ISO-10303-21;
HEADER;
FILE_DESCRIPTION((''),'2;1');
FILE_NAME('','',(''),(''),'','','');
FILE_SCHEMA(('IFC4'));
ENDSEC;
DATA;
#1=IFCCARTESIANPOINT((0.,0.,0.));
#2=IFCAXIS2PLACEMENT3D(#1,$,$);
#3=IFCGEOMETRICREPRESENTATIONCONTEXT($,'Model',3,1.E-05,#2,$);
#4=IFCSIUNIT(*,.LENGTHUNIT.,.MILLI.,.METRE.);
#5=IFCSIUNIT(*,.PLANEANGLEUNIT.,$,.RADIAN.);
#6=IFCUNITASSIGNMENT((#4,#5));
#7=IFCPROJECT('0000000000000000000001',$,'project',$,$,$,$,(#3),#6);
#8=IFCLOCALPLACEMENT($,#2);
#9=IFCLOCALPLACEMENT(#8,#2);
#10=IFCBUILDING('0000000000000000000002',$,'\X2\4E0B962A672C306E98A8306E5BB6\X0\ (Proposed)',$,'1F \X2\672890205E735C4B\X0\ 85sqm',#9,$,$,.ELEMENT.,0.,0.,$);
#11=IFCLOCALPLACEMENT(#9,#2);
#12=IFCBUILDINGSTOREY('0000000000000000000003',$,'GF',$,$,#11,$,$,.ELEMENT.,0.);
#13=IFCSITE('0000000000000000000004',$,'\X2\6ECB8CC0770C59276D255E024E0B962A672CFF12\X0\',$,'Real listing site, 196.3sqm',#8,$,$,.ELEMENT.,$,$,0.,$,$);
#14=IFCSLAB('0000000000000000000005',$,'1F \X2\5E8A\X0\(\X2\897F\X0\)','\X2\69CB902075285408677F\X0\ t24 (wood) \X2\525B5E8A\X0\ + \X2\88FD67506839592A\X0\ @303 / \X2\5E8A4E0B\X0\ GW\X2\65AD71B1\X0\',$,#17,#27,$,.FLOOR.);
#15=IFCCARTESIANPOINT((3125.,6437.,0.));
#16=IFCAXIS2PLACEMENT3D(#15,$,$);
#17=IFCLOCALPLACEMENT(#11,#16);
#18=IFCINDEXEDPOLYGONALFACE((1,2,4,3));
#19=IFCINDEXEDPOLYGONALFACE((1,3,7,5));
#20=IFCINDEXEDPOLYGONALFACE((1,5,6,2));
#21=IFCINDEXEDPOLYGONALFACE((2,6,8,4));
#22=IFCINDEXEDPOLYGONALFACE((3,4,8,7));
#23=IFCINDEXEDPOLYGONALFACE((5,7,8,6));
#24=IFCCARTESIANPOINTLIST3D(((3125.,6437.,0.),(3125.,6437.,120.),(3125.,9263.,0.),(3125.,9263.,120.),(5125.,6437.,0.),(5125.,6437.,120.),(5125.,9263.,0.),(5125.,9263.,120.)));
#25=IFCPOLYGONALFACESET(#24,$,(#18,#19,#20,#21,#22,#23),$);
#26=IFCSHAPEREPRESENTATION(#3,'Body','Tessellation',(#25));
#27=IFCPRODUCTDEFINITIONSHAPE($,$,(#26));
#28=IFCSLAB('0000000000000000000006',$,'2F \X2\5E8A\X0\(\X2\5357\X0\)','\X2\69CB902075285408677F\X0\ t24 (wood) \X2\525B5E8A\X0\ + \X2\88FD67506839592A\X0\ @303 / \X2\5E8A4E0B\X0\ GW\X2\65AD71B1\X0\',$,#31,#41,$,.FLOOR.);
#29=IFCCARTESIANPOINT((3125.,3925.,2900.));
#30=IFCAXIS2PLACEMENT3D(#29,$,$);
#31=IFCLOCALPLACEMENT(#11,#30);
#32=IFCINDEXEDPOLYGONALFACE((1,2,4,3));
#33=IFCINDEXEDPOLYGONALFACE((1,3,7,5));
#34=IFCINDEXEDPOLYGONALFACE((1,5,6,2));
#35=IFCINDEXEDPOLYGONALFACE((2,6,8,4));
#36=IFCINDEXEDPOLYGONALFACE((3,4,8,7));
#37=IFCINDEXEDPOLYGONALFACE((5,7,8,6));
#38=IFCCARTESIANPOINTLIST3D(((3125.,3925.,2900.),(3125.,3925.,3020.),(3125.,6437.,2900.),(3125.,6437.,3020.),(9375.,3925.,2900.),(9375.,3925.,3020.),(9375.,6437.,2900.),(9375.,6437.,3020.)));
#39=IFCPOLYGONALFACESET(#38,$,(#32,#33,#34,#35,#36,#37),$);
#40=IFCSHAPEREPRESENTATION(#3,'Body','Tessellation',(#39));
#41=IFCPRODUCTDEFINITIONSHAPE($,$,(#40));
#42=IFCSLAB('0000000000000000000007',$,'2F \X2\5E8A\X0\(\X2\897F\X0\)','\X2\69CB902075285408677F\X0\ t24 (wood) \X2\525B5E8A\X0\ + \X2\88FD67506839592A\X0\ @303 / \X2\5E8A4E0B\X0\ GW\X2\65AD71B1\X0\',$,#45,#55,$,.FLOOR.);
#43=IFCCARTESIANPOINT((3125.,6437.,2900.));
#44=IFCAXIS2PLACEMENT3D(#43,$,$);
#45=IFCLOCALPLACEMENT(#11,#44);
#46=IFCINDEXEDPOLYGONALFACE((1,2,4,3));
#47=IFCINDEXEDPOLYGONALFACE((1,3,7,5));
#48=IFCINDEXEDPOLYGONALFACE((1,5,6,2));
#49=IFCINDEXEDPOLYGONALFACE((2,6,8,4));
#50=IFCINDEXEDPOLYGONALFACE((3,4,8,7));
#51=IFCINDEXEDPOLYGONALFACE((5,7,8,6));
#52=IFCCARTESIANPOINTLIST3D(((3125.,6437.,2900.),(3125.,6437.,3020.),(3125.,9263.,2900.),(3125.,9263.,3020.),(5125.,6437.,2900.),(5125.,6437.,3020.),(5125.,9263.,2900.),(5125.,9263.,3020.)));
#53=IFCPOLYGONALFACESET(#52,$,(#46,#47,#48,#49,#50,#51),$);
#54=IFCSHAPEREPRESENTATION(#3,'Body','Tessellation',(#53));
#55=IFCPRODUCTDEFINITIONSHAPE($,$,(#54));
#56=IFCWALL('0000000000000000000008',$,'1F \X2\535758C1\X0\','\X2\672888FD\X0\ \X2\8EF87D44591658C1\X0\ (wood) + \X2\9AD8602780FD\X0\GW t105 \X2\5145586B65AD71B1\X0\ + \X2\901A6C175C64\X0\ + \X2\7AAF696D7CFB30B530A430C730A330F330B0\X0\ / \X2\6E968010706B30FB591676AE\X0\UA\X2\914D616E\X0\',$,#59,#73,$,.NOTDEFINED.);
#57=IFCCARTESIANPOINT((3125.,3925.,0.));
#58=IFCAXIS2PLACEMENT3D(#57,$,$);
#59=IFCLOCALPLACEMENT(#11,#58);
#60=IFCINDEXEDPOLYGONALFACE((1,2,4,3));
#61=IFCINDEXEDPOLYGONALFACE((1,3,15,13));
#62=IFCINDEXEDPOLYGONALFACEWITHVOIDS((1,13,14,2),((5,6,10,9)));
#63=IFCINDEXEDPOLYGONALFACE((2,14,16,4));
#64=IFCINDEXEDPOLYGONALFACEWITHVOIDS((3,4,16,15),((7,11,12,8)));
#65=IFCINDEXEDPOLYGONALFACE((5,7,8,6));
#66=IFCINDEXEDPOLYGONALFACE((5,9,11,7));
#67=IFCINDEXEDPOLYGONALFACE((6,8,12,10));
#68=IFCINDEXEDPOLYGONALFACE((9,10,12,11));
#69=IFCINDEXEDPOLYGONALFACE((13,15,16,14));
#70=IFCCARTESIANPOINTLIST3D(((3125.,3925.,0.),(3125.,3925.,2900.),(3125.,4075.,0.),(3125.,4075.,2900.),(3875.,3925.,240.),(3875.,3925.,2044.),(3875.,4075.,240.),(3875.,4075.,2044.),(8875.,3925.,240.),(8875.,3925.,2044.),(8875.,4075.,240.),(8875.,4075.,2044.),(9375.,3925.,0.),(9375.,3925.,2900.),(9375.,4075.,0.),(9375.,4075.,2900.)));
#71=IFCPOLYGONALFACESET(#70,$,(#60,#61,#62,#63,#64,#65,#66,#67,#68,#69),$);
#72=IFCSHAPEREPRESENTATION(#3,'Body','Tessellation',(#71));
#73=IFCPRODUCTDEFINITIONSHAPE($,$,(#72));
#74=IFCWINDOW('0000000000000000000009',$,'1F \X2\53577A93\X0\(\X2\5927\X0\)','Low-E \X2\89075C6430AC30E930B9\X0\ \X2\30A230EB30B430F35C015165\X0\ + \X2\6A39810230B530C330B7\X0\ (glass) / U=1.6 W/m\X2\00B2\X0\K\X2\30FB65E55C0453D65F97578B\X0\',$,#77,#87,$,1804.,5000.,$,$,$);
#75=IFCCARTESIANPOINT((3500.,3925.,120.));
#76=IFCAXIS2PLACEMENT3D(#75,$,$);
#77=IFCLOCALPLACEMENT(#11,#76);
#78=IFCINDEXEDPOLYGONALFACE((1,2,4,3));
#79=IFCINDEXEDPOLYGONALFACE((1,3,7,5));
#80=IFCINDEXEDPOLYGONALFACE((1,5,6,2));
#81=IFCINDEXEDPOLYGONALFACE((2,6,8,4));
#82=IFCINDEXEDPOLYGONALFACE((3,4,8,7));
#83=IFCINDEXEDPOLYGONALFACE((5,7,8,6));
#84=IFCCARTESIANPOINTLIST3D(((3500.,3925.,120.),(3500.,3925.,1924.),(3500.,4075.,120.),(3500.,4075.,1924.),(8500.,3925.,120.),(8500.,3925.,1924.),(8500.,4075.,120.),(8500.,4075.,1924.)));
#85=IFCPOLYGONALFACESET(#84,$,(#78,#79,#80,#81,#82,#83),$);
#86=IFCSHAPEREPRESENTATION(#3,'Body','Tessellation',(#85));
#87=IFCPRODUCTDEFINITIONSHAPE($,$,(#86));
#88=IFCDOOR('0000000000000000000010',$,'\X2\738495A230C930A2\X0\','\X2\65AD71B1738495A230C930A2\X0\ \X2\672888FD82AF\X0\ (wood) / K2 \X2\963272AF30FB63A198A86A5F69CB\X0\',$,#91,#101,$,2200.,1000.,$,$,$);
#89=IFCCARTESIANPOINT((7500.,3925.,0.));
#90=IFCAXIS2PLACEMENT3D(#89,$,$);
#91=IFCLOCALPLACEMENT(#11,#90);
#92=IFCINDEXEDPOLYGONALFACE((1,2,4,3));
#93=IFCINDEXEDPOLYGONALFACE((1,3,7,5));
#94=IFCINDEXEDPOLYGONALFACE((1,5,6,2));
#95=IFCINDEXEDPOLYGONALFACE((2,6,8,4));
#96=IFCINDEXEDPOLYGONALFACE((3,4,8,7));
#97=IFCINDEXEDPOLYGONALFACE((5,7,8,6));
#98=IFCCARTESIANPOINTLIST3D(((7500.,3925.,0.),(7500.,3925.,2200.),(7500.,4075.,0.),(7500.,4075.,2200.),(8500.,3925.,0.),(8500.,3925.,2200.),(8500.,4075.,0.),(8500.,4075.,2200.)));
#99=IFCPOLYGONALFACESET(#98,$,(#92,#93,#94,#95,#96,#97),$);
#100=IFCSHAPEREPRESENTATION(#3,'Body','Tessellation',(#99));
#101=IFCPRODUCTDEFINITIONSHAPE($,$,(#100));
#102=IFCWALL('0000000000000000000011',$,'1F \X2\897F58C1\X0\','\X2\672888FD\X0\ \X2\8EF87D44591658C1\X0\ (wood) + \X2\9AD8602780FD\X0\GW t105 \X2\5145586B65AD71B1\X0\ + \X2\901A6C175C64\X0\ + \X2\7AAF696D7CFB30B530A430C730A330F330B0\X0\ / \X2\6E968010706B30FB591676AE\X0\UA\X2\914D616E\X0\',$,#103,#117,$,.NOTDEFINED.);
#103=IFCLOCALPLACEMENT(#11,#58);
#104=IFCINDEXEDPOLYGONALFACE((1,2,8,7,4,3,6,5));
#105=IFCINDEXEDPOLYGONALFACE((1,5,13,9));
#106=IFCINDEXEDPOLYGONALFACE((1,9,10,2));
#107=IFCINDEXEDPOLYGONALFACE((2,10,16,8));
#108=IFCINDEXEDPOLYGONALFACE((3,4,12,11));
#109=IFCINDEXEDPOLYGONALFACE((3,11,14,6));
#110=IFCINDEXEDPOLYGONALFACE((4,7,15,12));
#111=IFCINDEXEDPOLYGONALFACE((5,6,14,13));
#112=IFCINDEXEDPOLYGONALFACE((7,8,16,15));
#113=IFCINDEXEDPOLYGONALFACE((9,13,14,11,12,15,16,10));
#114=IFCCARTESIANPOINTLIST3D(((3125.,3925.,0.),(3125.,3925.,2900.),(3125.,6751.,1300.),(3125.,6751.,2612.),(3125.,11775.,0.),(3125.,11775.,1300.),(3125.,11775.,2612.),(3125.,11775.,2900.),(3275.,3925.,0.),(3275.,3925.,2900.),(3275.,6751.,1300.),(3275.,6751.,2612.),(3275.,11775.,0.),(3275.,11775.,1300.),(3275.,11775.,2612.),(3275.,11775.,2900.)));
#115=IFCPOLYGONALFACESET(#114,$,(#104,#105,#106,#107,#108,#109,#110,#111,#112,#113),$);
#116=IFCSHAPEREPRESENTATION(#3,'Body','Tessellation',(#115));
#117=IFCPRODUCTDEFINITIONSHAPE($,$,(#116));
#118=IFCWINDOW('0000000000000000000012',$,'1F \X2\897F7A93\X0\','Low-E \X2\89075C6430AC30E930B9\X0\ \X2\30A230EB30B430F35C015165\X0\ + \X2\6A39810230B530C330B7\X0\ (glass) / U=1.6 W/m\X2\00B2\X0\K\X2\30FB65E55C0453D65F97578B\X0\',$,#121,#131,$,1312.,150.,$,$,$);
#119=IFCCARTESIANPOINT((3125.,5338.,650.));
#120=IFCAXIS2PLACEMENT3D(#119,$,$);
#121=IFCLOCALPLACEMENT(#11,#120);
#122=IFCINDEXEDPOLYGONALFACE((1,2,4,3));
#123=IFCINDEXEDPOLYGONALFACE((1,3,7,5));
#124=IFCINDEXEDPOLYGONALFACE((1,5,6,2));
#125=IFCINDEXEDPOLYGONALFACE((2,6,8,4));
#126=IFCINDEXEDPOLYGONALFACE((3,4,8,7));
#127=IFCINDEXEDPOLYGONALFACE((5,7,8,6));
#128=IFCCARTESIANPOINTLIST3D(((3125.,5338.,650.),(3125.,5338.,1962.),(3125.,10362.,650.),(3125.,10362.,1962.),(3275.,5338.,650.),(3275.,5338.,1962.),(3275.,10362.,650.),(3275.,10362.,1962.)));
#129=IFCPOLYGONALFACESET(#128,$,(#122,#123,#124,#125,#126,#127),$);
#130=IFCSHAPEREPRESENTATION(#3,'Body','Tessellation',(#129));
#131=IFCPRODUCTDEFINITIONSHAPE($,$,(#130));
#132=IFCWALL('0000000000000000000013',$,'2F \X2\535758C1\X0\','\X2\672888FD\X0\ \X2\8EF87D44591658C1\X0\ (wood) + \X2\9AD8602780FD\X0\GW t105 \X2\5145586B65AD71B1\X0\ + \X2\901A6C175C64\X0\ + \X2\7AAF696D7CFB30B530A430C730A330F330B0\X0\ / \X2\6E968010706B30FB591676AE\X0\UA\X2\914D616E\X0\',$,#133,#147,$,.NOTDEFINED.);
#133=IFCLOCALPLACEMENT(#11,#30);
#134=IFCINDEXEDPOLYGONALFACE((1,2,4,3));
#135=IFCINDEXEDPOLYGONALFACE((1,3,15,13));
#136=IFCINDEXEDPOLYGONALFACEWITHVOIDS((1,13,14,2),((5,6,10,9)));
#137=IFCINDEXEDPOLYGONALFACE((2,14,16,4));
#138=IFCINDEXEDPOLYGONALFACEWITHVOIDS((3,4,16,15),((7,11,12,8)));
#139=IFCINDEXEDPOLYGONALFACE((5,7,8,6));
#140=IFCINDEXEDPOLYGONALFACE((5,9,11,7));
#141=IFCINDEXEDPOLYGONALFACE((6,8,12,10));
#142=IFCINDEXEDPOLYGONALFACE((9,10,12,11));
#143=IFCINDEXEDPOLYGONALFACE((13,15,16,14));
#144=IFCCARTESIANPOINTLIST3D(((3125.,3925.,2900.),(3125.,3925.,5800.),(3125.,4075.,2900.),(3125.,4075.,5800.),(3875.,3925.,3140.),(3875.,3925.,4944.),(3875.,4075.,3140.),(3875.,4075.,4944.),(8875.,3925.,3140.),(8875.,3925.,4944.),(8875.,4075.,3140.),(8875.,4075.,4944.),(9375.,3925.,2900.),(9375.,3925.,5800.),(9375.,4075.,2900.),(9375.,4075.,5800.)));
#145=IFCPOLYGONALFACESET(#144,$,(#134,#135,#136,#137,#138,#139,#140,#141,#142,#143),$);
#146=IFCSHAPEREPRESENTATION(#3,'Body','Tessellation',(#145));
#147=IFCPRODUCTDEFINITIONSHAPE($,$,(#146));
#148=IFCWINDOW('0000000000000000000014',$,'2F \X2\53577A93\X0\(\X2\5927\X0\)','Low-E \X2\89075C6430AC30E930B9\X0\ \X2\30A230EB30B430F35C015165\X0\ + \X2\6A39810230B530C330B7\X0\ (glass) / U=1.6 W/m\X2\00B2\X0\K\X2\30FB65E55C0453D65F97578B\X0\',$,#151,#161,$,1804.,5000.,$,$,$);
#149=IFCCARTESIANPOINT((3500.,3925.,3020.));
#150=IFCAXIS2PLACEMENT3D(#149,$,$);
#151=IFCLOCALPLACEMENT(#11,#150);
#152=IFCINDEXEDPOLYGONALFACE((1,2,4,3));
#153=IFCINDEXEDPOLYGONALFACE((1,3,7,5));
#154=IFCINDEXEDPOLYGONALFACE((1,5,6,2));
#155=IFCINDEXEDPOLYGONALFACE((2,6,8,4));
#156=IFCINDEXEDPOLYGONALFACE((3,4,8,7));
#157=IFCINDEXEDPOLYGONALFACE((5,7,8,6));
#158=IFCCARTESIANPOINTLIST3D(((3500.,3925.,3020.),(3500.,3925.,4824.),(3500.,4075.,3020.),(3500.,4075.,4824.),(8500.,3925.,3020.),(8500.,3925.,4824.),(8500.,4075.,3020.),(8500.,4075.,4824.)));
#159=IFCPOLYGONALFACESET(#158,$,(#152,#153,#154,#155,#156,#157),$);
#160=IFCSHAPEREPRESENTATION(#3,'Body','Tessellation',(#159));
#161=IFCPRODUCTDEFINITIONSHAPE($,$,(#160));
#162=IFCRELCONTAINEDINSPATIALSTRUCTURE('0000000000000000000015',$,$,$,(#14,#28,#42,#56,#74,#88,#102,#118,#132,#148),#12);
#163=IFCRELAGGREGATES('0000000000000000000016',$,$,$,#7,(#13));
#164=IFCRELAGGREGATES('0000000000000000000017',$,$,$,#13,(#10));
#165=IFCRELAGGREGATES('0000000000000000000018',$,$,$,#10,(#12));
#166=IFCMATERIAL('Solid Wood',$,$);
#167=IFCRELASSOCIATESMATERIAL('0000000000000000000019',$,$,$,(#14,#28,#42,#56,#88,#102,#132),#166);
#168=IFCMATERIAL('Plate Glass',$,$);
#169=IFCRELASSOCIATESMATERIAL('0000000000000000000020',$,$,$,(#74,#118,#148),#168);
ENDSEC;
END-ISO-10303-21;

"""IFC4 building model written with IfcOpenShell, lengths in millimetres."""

from ifc_helpers import new_model, si_unit, frame, frame_2d, origin, place, context, project, spatial, rectangle, extrude, material, element, fill, save


model = new_model("IFC4")

# Units and contexts
model_context = context("Model", 3, precision=1e-05, world=origin())
ifc_project = project(units=[si_unit("LENGTHUNIT", "METRE", prefix="MILLI"), si_unit("PLANEANGLEUNIT", "RADIAN")], contexts=[model_context])

# Site, building, storey
site_placement = place(None, origin())
site = spatial("IfcSite", under=ifc_project, at=site_placement, Name="滋賀県大津市下阪本２", ObjectType="Real listing site, 196.3sqm", CompositionType="ELEMENT", RefElevation=0.0)
building_placement = place(site_placement, origin())
building = spatial("IfcBuilding", under=site, at=building_placement, Name="下阪本の風の家 (Proposed)", ObjectType="1F 木造平屋 85sqm", CompositionType="ELEMENT", ElevationOfRefHeight=0.0, ElevationOfTerrain=0.0)
storey_placement = place(building_placement, origin())
storey = spatial("IfcBuildingStorey", under=building, at=storey_placement, Name="GF", CompositionType="ELEMENT", Elevation=0.0)

# Slabs
ifc_material_1 = material(Name="Solid Wood")
slab_1_placement = place(storey_placement, frame((3125.0, 6437.0, 0.0)))
element("IfcSlab", 1, at=slab_1_placement, inside=storey, material=ifc_material_1, Name="1F 床(西)", Description="構造用合板 t24 (wood) 剛床 + 製材根太 @303 / 床下 GW断熱", PredefinedType="FLOOR", context=model_context, shape_type="SweptSolid", body=[
    extrude(rectangle(XDim=2000.0, YDim=2826.0, at=frame_2d((1000.0, 1413.0))), frame((3125.0, 6437.0, 0.0)), (0.0, 0.0, 1.0), 120.0),
])
slab_2_placement = place(storey_placement, frame((3125.0, 3925.0, 2900.0)))
element("IfcSlab", 2, at=slab_2_placement, inside=storey, material=ifc_material_1, Name="2F 床(南)", Description="構造用合板 t24 (wood) 剛床 + 製材根太 @303 / 床下 GW断熱", PredefinedType="FLOOR", context=model_context, shape_type="SweptSolid", body=[
    extrude(rectangle(XDim=6250.0, YDim=2512.0, at=frame_2d((3125.0, 1256.0))), frame((3125.0, 3925.0, 2900.0)), (0.0, 0.0, 1.0), 120.0),
])
slab_3_placement = place(storey_placement, frame((3125.0, 6437.0, 2900.0)))
element("IfcSlab", 3, at=slab_3_placement, inside=storey, material=ifc_material_1, Name="2F 床(西)", Description="構造用合板 t24 (wood) 剛床 + 製材根太 @303 / 床下 GW断熱", PredefinedType="FLOOR", context=model_context, shape_type="SweptSolid", body=[
    extrude(rectangle(XDim=2000.0, YDim=2826.0, at=frame_2d((1000.0, 1413.0))), frame((3125.0, 6437.0, 2900.0)), (0.0, 0.0, 1.0), 120.0),
])

# Wall, openings, window, door
wall_1_placement = place(storey_placement, frame((3125.0, 3925.0, 0.0)))
wall_1 = element("IfcWall", 4, at=wall_1_placement, inside=storey, material=ifc_material_1, Name="1F 南壁", Description="木製 軸組外壁 (wood) + 高性能GW t105 充填断熱 + 通気層 + 窯業系サイディング / 準耐火・外皮UA配慮", PredefinedType="NOTDEFINED", context=model_context, shape_type="SweptSolid", body=[
    extrude(rectangle(XDim=6250.0, YDim=150.0, at=frame_2d((3125.0, 75.0))), frame((3125.0, 3925.0, 0.0)), (0.0, 0.0, 1.0), 2900.0),
])
opening_1_placement = place(storey_placement, frame((3500.0, 3925.0, 120.0)))
opening_1 = element("IfcOpeningElement", 5, at=opening_1_placement, cuts=wall_1, PredefinedType="NOTDEFINED", context=model_context, shape_type="SweptSolid", body=[
    extrude(rectangle(XDim=5000.0, YDim=150.0, at=frame_2d((2500.0, 75.0))), frame((3500.0, 3925.0, 120.0)), (0.0, 0.0, 1.0), 1804.0),
])
opening_2_placement = place(storey_placement, frame((7500.0, 3925.0, 0.0)))
opening_2 = element("IfcOpeningElement", 6, at=opening_2_placement, cuts=wall_1, PredefinedType="NOTDEFINED", context=model_context, shape_type="SweptSolid", body=[
    extrude(rectangle(XDim=1000.0, YDim=150.0, at=frame_2d((500.0, 75.0))), frame((7500.0, 3925.0, 0.0)), (0.0, 0.0, 1.0), 2200.0),
])
ifc_material_2 = material(Name="Plate Glass")
window_1_placement = place(storey_placement, frame((3500.0, 3925.0, 120.0)))
window_1 = element("IfcWindow", 7, at=window_1_placement, inside=storey, material=ifc_material_2, Name="1F 南窓(大)", Description="Low-E 複層ガラス アルゴン封入 + 樹脂サッシ (glass) / U=1.6 W/m²K・日射取得型", OverallHeight=1804.0, OverallWidth=5000.0, context=model_context, shape_type="SweptSolid", body=[
    extrude(rectangle(XDim=5000.0, YDim=150.0, at=frame_2d((2500.0, 75.0))), frame((3500.0, 3925.0, 120.0)), (0.0, 0.0, 1.0), 1804.0),
])
fill(opening_1, window_1)
door_placement = place(storey_placement, frame((7500.0, 3925.0, 0.0)))
door = element("IfcDoor", 8, at=door_placement, inside=storey, material=ifc_material_1, Name="玄関ドア", Description="断熱玄関ドア 木製芯 (wood) / K2 防犯・採風機構", OverallHeight=2200.0, OverallWidth=1000.0, context=model_context, shape_type="SweptSolid", body=[
    extrude(rectangle(XDim=1000.0, YDim=150.0, at=frame_2d((500.0, 75.0))), frame((7500.0, 3925.0, 0.0)), (0.0, 0.0, 1.0), 2200.0),
])
fill(opening_2, door)

# Walls, openings, windows
wall_2_placement = place(storey_placement, frame((3125.0, 3925.0, 0.0)))
wall_2 = element("IfcWall", 9, at=wall_2_placement, inside=storey, material=ifc_material_1, Name="1F 西壁", Description="木製 軸組外壁 (wood) + 高性能GW t105 充填断熱 + 通気層 + 窯業系サイディング / 準耐火・外皮UA配慮", PredefinedType="NOTDEFINED", context=model_context, shape_type="SweptSolid", body=[
    extrude(rectangle(XDim=150.0, YDim=7850.0, at=frame_2d((75.0, 3925.0))), frame((3125.0, 3925.0, 0.0)), (0.0, 0.0, 1.0), 2900.0),
])
opening_3_placement = place(storey_placement, frame((3125.0, 5338.0, 650.0)))
opening_3 = element("IfcOpeningElement", 10, at=opening_3_placement, cuts=wall_2, PredefinedType="NOTDEFINED", context=model_context, shape_type="SweptSolid", body=[
    extrude(rectangle(XDim=150.0, YDim=5024.0, at=frame_2d((75.0, 2512.0))), frame((3125.0, 5338.0, 650.0)), (0.0, 0.0, 1.0), 1312.0),
])
window_2_placement = place(storey_placement, frame((3125.0, 5338.0, 650.0)))
window_2 = element("IfcWindow", 11, at=window_2_placement, inside=storey, material=ifc_material_2, Name="1F 西窓", Description="Low-E 複層ガラス アルゴン封入 + 樹脂サッシ (glass) / U=1.6 W/m²K・日射取得型", OverallHeight=1312.0, OverallWidth=150.0, context=model_context, shape_type="SweptSolid", body=[
    extrude(rectangle(XDim=150.0, YDim=5024.0, at=frame_2d((75.0, 2512.0))), frame((3125.0, 5338.0, 650.0)), (0.0, 0.0, 1.0), 1312.0),
])
fill(opening_3, window_2)
wall_3_placement = place(storey_placement, frame((3125.0, 3925.0, 2900.0)))
wall_3 = element("IfcWall", 12, at=wall_3_placement, inside=storey, material=ifc_material_1, Name="2F 南壁", Description="木製 軸組外壁 (wood) + 高性能GW t105 充填断熱 + 通気層 + 窯業系サイディング / 準耐火・外皮UA配慮", PredefinedType="NOTDEFINED", context=model_context, shape_type="SweptSolid", body=[
    extrude(rectangle(XDim=6250.0, YDim=150.0, at=frame_2d((3125.0, 75.0))), frame((3125.0, 3925.0, 2900.0)), (0.0, 0.0, 1.0), 2900.0),
])
opening_4_placement = place(storey_placement, frame((3500.0, 3925.0, 3020.0)))
opening_4 = element("IfcOpeningElement", 13, at=opening_4_placement, cuts=wall_3, PredefinedType="NOTDEFINED", context=model_context, shape_type="SweptSolid", body=[
    extrude(rectangle(XDim=5000.0, YDim=150.0, at=frame_2d((2500.0, 75.0))), frame((3500.0, 3925.0, 3020.0)), (0.0, 0.0, 1.0), 1804.0),
])
window_3_placement = place(storey_placement, frame((3500.0, 3925.0, 3020.0)))
window_3 = element("IfcWindow", 14, at=window_3_placement, inside=storey, material=ifc_material_2, Name="2F 南窓(大)", Description="Low-E 複層ガラス アルゴン封入 + 樹脂サッシ (glass) / U=1.6 W/m²K・日射取得型", OverallHeight=1804.0, OverallWidth=5000.0, context=model_context, shape_type="SweptSolid", body=[
    extrude(rectangle(XDim=5000.0, YDim=150.0, at=frame_2d((2500.0, 75.0))), frame((3500.0, 3925.0, 3020.0)), (0.0, 0.0, 1.0), 1804.0),
])
fill(opening_4, window_3)

save(model, "model.ifc")
